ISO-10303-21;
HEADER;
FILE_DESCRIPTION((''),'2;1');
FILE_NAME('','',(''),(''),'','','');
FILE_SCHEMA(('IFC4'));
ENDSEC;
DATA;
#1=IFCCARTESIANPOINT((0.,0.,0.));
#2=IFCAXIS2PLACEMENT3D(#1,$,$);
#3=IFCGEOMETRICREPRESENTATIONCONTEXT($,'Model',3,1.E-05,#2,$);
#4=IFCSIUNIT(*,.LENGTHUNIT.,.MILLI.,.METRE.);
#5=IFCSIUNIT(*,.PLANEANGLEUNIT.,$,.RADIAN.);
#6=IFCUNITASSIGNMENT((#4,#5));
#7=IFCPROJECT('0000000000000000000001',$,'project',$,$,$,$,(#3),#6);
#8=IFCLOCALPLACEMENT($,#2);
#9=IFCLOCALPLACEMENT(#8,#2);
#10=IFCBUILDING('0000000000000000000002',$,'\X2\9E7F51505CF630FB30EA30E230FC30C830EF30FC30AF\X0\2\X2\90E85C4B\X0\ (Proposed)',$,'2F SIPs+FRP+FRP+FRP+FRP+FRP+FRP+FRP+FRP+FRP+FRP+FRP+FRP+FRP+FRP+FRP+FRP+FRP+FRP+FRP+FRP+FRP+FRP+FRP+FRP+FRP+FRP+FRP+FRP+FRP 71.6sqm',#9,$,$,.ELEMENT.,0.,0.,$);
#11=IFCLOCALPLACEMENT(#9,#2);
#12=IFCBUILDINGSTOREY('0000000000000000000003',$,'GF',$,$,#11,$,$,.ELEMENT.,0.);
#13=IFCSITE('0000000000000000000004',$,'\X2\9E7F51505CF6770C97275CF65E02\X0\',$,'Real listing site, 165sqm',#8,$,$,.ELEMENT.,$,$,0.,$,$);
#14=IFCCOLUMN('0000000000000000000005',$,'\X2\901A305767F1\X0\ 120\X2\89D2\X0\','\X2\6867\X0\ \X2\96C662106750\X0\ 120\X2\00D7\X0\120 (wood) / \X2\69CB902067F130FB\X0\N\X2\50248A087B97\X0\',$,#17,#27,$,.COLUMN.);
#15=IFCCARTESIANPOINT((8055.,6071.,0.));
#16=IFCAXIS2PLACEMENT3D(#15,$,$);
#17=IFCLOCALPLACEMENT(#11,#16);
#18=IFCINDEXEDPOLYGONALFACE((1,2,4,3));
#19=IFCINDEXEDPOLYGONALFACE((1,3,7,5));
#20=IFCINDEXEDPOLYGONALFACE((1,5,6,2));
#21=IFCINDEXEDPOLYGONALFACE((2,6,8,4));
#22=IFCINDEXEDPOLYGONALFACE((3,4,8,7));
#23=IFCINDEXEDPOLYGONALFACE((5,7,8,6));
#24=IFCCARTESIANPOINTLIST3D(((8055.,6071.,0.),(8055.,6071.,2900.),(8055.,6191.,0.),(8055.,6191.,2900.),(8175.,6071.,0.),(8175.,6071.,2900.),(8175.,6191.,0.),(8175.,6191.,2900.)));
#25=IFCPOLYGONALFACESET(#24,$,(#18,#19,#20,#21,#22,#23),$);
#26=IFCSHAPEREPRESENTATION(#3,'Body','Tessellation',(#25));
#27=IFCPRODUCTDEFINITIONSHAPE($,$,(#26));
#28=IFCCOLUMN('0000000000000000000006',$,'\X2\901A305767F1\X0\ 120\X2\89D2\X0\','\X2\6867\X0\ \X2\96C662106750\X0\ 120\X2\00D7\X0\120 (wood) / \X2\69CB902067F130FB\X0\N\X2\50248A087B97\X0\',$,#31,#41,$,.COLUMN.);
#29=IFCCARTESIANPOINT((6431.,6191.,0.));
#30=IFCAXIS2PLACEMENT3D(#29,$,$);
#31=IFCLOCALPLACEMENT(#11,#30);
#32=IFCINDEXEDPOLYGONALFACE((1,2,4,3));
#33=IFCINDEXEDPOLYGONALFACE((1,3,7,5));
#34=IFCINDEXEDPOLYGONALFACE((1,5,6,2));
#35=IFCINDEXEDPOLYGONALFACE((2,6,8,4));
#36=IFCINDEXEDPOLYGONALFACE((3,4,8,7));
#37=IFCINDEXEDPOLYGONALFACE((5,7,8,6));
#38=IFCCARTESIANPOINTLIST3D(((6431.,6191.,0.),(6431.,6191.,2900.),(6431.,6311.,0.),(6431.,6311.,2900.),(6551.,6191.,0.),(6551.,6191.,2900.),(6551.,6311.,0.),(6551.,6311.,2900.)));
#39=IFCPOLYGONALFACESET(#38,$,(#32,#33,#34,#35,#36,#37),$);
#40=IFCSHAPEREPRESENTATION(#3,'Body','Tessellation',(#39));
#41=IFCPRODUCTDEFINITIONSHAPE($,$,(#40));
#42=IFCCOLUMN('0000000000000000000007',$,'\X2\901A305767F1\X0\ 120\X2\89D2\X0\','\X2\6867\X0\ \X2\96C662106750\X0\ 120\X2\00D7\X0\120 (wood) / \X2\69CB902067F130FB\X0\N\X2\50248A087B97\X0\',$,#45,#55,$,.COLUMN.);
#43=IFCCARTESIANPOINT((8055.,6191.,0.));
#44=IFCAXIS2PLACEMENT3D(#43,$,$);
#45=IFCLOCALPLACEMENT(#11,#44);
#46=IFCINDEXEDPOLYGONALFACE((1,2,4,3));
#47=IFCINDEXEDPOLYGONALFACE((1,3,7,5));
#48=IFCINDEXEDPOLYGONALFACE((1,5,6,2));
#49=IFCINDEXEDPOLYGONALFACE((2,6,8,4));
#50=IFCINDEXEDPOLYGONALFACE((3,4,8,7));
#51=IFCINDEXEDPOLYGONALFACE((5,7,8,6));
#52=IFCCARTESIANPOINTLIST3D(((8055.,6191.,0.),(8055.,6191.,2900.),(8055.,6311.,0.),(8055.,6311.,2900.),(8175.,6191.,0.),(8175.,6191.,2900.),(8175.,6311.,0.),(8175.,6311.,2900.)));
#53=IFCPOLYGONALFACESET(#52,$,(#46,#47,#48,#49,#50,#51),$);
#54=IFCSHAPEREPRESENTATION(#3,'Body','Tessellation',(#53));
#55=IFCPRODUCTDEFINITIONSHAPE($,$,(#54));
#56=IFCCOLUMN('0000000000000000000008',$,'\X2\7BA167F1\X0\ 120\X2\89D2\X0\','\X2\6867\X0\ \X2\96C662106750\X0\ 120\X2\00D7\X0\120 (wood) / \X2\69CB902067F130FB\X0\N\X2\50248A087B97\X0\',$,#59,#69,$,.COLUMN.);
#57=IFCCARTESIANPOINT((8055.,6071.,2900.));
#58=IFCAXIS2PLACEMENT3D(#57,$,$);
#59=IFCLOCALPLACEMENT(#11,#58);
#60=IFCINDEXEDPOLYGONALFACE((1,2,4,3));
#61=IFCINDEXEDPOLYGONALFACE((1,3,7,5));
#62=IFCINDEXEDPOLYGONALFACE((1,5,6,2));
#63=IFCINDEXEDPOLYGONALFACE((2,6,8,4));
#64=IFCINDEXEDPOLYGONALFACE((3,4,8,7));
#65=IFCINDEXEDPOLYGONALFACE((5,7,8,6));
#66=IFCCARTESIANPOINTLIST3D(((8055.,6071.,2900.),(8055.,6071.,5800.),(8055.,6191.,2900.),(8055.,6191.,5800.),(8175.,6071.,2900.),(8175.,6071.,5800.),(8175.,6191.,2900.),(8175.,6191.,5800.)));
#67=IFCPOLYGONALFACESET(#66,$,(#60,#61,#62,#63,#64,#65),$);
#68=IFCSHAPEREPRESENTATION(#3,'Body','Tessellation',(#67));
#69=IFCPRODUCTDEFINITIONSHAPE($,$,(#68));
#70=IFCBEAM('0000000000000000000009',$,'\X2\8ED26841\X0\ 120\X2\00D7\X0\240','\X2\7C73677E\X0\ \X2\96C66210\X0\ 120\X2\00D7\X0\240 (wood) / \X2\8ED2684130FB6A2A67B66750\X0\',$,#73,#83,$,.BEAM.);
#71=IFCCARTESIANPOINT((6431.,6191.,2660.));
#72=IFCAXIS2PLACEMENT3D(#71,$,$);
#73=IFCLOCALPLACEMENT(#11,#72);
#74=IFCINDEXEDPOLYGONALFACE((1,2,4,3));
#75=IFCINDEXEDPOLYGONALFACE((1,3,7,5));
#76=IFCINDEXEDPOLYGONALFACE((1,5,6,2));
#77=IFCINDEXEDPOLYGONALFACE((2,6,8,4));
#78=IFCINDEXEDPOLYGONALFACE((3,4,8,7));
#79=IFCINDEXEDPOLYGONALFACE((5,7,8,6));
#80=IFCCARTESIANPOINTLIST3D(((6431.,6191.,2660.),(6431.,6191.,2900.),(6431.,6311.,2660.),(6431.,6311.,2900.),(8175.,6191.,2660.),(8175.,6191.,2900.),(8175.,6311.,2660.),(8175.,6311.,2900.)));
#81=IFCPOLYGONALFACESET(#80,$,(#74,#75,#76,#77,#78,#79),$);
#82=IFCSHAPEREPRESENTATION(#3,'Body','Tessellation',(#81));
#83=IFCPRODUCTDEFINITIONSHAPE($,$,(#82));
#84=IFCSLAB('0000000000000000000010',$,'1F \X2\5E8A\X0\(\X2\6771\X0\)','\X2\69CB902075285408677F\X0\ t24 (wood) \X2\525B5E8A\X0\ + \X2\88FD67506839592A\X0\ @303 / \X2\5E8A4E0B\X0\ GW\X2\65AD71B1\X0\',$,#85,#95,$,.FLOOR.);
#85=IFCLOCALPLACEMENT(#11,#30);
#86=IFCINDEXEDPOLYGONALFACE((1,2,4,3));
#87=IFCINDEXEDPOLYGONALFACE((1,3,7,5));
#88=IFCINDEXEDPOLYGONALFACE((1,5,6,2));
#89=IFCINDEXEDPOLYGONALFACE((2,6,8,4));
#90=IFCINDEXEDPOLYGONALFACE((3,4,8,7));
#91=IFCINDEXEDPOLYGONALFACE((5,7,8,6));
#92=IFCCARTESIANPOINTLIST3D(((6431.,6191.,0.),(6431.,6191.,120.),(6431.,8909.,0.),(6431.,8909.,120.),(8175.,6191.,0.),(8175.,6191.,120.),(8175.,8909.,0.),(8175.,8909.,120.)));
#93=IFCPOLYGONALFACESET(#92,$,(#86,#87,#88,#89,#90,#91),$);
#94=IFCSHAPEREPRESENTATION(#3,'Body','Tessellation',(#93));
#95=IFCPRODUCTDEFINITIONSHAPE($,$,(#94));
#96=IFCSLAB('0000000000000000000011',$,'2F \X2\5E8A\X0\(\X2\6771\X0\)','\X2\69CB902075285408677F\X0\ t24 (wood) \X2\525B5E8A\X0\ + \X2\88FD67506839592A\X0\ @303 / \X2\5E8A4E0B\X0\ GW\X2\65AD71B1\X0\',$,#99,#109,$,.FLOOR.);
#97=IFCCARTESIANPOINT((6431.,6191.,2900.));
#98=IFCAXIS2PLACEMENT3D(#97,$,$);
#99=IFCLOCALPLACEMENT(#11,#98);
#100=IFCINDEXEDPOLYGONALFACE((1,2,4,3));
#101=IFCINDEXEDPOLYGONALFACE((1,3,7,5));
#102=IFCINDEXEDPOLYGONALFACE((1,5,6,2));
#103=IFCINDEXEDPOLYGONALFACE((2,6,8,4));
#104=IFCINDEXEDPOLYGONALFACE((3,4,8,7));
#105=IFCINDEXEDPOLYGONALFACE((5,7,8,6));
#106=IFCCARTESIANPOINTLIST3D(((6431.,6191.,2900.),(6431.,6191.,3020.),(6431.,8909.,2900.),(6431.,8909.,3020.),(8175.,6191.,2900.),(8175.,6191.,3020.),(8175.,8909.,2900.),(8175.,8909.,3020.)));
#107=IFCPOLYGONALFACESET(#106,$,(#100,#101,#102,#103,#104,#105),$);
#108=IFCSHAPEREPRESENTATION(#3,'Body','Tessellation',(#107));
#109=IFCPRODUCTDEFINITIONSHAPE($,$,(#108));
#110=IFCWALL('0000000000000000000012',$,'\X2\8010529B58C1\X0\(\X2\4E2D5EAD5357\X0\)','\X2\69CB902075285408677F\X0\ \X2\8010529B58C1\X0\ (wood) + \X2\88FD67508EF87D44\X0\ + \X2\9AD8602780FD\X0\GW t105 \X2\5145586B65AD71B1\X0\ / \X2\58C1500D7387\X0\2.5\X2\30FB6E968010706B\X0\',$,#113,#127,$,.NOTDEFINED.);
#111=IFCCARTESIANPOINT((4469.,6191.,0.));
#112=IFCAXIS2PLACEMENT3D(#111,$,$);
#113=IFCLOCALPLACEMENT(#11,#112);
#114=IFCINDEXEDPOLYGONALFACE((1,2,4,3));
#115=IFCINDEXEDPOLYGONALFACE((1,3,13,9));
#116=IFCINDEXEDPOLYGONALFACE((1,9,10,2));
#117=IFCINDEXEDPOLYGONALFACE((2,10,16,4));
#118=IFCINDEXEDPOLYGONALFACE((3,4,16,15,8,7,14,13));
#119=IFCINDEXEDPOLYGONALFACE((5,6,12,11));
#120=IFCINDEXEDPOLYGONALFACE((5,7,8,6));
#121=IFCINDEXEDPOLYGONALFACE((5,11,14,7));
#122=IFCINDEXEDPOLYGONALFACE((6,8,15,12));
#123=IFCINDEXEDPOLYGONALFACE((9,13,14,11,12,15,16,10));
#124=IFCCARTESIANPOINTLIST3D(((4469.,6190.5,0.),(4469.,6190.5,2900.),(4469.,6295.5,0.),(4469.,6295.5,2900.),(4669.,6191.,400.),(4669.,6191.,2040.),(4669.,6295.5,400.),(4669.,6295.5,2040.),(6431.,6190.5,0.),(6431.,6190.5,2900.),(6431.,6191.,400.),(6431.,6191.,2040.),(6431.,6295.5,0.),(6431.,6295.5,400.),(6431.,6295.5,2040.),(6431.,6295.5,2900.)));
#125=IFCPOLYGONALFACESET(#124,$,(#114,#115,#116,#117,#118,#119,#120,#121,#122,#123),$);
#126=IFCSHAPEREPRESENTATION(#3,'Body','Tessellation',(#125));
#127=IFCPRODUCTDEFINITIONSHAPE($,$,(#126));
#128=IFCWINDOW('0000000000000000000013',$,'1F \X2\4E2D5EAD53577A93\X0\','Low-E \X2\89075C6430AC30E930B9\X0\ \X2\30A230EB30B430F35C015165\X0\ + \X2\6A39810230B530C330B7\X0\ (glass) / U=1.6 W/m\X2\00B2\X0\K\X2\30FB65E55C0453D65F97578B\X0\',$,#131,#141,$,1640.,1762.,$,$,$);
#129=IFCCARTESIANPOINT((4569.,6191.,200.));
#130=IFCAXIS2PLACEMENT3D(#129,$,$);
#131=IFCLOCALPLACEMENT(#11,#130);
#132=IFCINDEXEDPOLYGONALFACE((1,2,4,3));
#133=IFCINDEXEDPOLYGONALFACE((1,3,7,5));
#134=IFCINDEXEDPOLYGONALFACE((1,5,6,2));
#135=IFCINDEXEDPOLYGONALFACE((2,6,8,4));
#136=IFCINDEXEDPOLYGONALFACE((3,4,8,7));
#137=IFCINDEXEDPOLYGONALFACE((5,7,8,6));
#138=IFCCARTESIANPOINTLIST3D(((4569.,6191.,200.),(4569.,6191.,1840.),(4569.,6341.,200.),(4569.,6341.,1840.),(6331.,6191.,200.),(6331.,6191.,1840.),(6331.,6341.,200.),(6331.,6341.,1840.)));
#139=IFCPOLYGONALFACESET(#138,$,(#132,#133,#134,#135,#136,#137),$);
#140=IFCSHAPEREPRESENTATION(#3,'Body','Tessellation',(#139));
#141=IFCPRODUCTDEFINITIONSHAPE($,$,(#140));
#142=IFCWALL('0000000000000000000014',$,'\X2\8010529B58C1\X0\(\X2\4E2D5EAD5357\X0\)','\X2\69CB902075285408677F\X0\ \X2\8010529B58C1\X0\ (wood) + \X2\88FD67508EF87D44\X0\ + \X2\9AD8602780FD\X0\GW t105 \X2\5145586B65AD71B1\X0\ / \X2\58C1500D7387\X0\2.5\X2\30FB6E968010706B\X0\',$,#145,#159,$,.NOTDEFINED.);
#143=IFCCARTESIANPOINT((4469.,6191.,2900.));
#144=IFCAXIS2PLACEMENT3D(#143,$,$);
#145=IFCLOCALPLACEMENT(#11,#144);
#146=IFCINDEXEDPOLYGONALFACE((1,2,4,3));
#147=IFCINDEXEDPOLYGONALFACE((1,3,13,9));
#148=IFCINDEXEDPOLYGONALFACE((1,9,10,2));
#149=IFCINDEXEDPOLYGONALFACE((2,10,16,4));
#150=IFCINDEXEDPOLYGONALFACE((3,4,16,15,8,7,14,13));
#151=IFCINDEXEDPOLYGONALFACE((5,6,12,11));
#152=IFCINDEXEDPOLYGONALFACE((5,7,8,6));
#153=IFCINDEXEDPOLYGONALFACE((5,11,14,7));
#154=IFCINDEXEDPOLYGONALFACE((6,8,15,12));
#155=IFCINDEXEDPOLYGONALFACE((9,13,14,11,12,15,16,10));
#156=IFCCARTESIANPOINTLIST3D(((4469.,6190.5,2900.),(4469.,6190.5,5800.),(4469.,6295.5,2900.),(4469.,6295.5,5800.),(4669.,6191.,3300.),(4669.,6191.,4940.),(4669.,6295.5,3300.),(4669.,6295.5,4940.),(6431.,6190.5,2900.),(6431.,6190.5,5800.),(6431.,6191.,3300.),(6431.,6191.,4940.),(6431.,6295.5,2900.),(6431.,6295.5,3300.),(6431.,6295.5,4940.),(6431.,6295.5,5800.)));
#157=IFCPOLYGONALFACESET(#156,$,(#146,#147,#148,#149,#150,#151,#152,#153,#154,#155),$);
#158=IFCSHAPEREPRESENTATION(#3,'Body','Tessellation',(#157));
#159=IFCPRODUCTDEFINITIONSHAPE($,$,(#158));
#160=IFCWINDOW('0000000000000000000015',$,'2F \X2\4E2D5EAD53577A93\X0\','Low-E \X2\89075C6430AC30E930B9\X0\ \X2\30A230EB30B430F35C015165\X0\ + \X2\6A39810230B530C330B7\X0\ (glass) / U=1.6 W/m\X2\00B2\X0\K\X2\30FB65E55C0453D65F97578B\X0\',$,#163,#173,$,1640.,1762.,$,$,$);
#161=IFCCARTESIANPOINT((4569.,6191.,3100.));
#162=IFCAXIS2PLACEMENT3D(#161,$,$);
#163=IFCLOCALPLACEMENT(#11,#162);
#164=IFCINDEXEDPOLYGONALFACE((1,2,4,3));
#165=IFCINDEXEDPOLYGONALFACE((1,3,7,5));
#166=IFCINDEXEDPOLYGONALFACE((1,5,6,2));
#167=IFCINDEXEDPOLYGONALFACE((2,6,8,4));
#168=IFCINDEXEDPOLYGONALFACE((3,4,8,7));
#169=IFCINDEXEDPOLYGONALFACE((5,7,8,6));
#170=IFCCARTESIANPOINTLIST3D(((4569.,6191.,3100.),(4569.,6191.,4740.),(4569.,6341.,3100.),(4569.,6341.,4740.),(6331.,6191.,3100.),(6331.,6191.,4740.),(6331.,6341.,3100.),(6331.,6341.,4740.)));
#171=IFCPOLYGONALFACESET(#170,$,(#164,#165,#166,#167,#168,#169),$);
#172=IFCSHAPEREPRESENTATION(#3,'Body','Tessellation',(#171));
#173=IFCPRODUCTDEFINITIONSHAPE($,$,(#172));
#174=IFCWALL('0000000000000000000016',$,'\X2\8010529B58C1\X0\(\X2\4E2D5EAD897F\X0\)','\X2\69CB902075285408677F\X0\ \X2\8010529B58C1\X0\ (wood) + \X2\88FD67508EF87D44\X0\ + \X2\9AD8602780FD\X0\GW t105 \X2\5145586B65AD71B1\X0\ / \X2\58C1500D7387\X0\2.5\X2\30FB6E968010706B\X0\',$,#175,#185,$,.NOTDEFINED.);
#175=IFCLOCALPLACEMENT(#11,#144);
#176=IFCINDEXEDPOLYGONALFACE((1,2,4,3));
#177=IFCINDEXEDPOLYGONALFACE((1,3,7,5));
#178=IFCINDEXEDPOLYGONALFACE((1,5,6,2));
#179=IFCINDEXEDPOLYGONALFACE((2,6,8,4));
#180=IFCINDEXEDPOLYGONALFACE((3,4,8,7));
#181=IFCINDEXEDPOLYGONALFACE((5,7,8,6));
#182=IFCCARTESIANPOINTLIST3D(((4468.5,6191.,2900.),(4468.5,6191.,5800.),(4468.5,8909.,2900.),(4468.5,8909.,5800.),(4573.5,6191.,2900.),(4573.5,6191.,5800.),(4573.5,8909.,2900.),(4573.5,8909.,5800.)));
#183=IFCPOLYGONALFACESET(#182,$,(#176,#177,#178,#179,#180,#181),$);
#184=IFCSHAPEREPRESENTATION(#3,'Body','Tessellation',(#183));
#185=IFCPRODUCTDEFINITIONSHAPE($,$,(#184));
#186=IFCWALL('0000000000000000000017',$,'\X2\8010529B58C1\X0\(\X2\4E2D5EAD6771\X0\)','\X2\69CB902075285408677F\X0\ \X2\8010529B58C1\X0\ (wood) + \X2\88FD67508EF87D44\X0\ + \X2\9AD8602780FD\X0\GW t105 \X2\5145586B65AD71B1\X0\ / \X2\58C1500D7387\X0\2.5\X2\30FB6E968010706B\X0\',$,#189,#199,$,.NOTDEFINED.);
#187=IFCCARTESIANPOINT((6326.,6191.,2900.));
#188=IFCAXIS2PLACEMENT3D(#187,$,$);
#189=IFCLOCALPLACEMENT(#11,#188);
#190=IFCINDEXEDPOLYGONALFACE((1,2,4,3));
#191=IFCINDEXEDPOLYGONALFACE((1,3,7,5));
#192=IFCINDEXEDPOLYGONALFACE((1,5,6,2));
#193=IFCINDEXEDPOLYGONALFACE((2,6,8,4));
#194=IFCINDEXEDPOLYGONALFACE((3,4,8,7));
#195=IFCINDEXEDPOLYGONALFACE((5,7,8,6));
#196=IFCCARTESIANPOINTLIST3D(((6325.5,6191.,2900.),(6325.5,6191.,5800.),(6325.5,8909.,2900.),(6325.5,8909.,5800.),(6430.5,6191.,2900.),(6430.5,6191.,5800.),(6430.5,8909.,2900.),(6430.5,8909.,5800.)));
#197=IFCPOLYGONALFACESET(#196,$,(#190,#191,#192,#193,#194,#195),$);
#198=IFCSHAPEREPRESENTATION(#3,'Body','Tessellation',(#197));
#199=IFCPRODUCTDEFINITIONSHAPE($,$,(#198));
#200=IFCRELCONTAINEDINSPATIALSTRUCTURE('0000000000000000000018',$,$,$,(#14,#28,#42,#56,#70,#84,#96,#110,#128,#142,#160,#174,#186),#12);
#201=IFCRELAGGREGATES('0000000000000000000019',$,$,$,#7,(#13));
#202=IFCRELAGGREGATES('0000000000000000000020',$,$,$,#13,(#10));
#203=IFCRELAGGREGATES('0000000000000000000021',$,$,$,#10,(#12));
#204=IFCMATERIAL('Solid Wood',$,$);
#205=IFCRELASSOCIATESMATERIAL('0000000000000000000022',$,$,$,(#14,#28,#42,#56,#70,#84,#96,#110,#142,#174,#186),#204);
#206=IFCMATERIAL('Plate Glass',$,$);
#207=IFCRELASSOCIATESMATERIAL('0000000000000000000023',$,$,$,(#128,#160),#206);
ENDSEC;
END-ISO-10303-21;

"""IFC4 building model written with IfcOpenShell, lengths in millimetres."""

from ifc_helpers import new_model, si_unit, frame, frame_2d, origin, place, context, project, spatial, rectangle, extrude, material, element, fill, save


model = new_model("IFC4")

# Units and contexts
model_context = context("Model", 3, precision=1e-05, world=origin())
ifc_project = project(units=[si_unit("LENGTHUNIT", "METRE", prefix="MILLI"), si_unit("PLANEANGLEUNIT", "RADIAN")], contexts=[model_context])

# Site, building, storey
site_placement = place(None, origin())
site = spatial("IfcSite", under=ifc_project, at=site_placement, Name="鹿児島県霧島市", ObjectType="Real listing site, 165sqm", CompositionType="ELEMENT", RefElevation=0.0)
building_placement = place(site_placement, origin())
building = spatial("IfcBuilding", under=site, at=building_placement, Name="鹿児島・リモートワーク2部屋 (Proposed)", ObjectType="2F SIPs+FRP+FRP+FRP+FRP+FRP+FRP+FRP+FRP+FRP+FRP+FRP+FRP+FRP+FRP+FRP+FRP+FRP+FRP+FRP+FRP+FRP+FRP+FRP+FRP+FRP+FRP+FRP+FRP+FRP 71.6sqm", CompositionType="ELEMENT", ElevationOfRefHeight=0.0, ElevationOfTerrain=0.0)
storey_placement = place(building_placement, origin())
storey = spatial("IfcBuildingStorey", under=building, at=storey_placement, Name="GF", CompositionType="ELEMENT", Elevation=0.0)

# Columns
ifc_material_1 = material(Name="Solid Wood")
column_1_placement = place(storey_placement, frame((8055.0, 6071.0, 0.0)))
element("IfcColumn", 1, at=column_1_placement, inside=storey, material=ifc_material_1, Name="通し柱 120角", Description="桧 集成材 120×120 (wood) / 構造柱・N値計算", PredefinedType="COLUMN", context=model_context, shape_type="SweptSolid", body=[
    extrude(rectangle(XDim=120.0, YDim=120.0, at=frame_2d((60.0, 60.0))), frame((8055.0, 6071.0, 0.0)), (0.0, 0.0, 1.0), 2900.0),
])
column_2_placement = place(storey_placement, frame((6431.0, 6191.0, 0.0)))
element("IfcColumn", 2, at=column_2_placement, inside=storey, material=ifc_material_1, Name="通し柱 120角", Description="桧 集成材 120×120 (wood) / 構造柱・N値計算", PredefinedType="COLUMN", context=model_context, shape_type="SweptSolid", body=[
    extrude(rectangle(XDim=120.0, YDim=120.0, at=frame_2d((60.0, 60.0))), frame((6431.0, 6191.0, 0.0)), (0.0, 0.0, 1.0), 2900.0),
])
column_3_placement = place(storey_placement, frame((8055.0, 6191.0, 0.0)))
element("IfcColumn", 3, at=column_3_placement, inside=storey, material=ifc_material_1, Name="通し柱 120角", Description="桧 集成材 120×120 (wood) / 構造柱・N値計算", PredefinedType="COLUMN", context=model_context, shape_type="SweptSolid", body=[
    extrude(rectangle(XDim=120.0, YDim=120.0, at=frame_2d((60.0, 60.0))), frame((8055.0, 6191.0, 0.0)), (0.0, 0.0, 1.0), 2900.0),
])
column_4_placement = place(storey_placement, frame((8055.0, 6071.0, 2900.0)))
element("IfcColumn", 4, at=column_4_placement, inside=storey, material=ifc_material_1, Name="管柱 120角", Description="桧 集成材 120×120 (wood) / 構造柱・N値計算", PredefinedType="COLUMN", context=model_context, shape_type="SweptSolid", body=[
    extrude(rectangle(XDim=120.0, YDim=120.0, at=frame_2d((60.0, 60.0))), frame((8055.0, 6071.0, 2900.0)), (0.0, 0.0, 1.0), 2900.0),
])

# Beam
beam_1_placement = place(storey_placement, frame((6431.0, 6191.0, 2660.0)))
element("IfcBeam", 5, at=beam_1_placement, inside=storey, material=ifc_material_1, Name="軒桁 120×240", Description="米松 集成 120×240 (wood) / 軒桁・横架材", PredefinedType="BEAM", context=model_context, shape_type="SweptSolid", body=[
    extrude(rectangle(XDim=1744.0, YDim=120.0, at=frame_2d((872.0, 60.0))), frame((6431.0, 6191.0, 2660.0)), (0.0, 0.0, 1.0), 240.0),
])

# Slabs
slab_1_placement = place(storey_placement, frame((6431.0, 6191.0, 0.0)))
element("IfcSlab", 6, at=slab_1_placement, inside=storey, material=ifc_material_1, Name="1F 床(東)", Description="構造用合板 t24 (wood) 剛床 + 製材根太 @303 / 床下 GW断熱", PredefinedType="FLOOR", context=model_context, shape_type="SweptSolid", body=[
    extrude(rectangle(XDim=1744.0, YDim=2718.0, at=frame_2d((872.0, 1359.0))), frame((6431.0, 6191.0, 0.0)), (0.0, 0.0, 1.0), 120.0),
])
slab_2_placement = place(storey_placement, frame((6431.0, 6191.0, 2900.0)))
element("IfcSlab", 7, at=slab_2_placement, inside=storey, material=ifc_material_1, Name="2F 床(東)", Description="構造用合板 t24 (wood) 剛床 + 製材根太 @303 / 床下 GW断熱", PredefinedType="FLOOR", context=model_context, shape_type="SweptSolid", body=[
    extrude(rectangle(XDim=1744.0, YDim=2718.0, at=frame_2d((872.0, 1359.0))), frame((6431.0, 6191.0, 2900.0)), (0.0, 0.0, 1.0), 120.0),
])

# Wall, opening, window
wall_1_placement = place(storey_placement, frame((4469.0, 6191.0, 0.0)))
wall_1 = element("IfcWall", 8, at=wall_1_placement, inside=storey, material=ifc_material_1, Name="耐力壁(中庭南)", Description="構造用合板 耐力壁 (wood) + 製材軸組 + 高性能GW t105 充填断熱 / 壁倍率2.5・準耐火", PredefinedType="NOTDEFINED", context=model_context, shape_type="SweptSolid", body=[
    extrude(rectangle(XDim=1962.0, YDim=105.0, at=frame_2d((981.0, 52.0))), frame((4469.0, 6191.0, 0.0)), (0.0, 0.0, 1.0), 2900.0),
])
opening_1_placement = place(storey_placement, frame((4569.0, 6191.0, 200.0)))
opening_1 = element("IfcOpeningElement", 9, at=opening_1_placement, cuts=wall_1, PredefinedType="NOTDEFINED", context=model_context, shape_type="SweptSolid", body=[
    extrude(rectangle(XDim=1762.0, YDim=150.0, at=frame_2d((881.0, 75.0))), frame((4569.0, 6191.0, 200.0)), (0.0, 0.0, 1.0), 1640.0),
])
ifc_material_2 = material(Name="Plate Glass")
window_1_placement = place(storey_placement, frame((4569.0, 6191.0, 200.0)))
window_1 = element("IfcWindow", 10, at=window_1_placement, inside=storey, material=ifc_material_2, Name="1F 中庭南窓", Description="Low-E 複層ガラス アルゴン封入 + 樹脂サッシ (glass) / U=1.6 W/m²K・日射取得型", OverallHeight=1640.0, OverallWidth=1762.0, context=model_context, shape_type="SweptSolid", body=[
    extrude(rectangle(XDim=1762.0, YDim=150.0, at=frame_2d((881.0, 75.0))), frame((4569.0, 6191.0, 200.0)), (0.0, 0.0, 1.0), 1640.0),
])
fill(opening_1, window_1)

# Wall, opening, window
wall_2_placement = place(storey_placement, frame((4469.0, 6191.0, 2900.0)))
wall_2 = element("IfcWall", 11, at=wall_2_placement, inside=storey, material=ifc_material_1, Name="耐力壁(中庭南)", Description="構造用合板 耐力壁 (wood) + 製材軸組 + 高性能GW t105 充填断熱 / 壁倍率2.5・準耐火", PredefinedType="NOTDEFINED", context=model_context, shape_type="SweptSolid", body=[
    extrude(rectangle(XDim=1962.0, YDim=105.0, at=frame_2d((981.0, 52.0))), frame((4469.0, 6191.0, 2900.0)), (0.0, 0.0, 1.0), 2900.0),
])
opening_2_placement = place(storey_placement, frame((4569.0, 6191.0, 3100.0)))
opening_2 = element("IfcOpeningElement", 12, at=opening_2_placement, cuts=wall_2, PredefinedType="NOTDEFINED", context=model_context, shape_type="SweptSolid", body=[
    extrude(rectangle(XDim=1762.0, YDim=150.0, at=frame_2d((881.0, 75.0))), frame((4569.0, 6191.0, 3100.0)), (0.0, 0.0, 1.0), 1640.0),
])
window_2_placement = place(storey_placement, frame((4569.0, 6191.0, 3100.0)))
window_2 = element("IfcWindow", 13, at=window_2_placement, inside=storey, material=ifc_material_2, Name="2F 中庭南窓", Description="Low-E 複層ガラス アルゴン封入 + 樹脂サッシ (glass) / U=1.6 W/m²K・日射取得型", OverallHeight=1640.0, OverallWidth=1762.0, context=model_context, shape_type="SweptSolid", body=[
    extrude(rectangle(XDim=1762.0, YDim=150.0, at=frame_2d((881.0, 75.0))), frame((4569.0, 6191.0, 3100.0)), (0.0, 0.0, 1.0), 1640.0),
])
fill(opening_2, window_2)

# Walls
wall_3_placement = place(storey_placement, frame((4469.0, 6191.0, 2900.0)))
element("IfcWall", 14, at=wall_3_placement, inside=storey, material=ifc_material_1, Name="耐力壁(中庭西)", Description="構造用合板 耐力壁 (wood) + 製材軸組 + 高性能GW t105 充填断熱 / 壁倍率2.5・準耐火", PredefinedType="NOTDEFINED", context=model_context, shape_type="SweptSolid", body=[
    extrude(rectangle(XDim=105.0, YDim=2718.0, at=frame_2d((52.0, 1359.0))), frame((4469.0, 6191.0, 2900.0)), (0.0, 0.0, 1.0), 2900.0),
])
wall_4_placement = place(storey_placement, frame((6326.0, 6191.0, 2900.0)))
element("IfcWall", 15, at=wall_4_placement, inside=storey, material=ifc_material_1, Name="耐力壁(中庭東)", Description="構造用合板 耐力壁 (wood) + 製材軸組 + 高性能GW t105 充填断熱 / 壁倍率2.5・準耐火", PredefinedType="NOTDEFINED", context=model_context, shape_type="SweptSolid", body=[
    extrude(rectangle(XDim=105.0, YDim=2718.0, at=frame_2d((52.0, 1359.0))), frame((6326.0, 6191.0, 2900.0)), (0.0, 0.0, 1.0), 2900.0),
])

save(model, "model.ifc")
